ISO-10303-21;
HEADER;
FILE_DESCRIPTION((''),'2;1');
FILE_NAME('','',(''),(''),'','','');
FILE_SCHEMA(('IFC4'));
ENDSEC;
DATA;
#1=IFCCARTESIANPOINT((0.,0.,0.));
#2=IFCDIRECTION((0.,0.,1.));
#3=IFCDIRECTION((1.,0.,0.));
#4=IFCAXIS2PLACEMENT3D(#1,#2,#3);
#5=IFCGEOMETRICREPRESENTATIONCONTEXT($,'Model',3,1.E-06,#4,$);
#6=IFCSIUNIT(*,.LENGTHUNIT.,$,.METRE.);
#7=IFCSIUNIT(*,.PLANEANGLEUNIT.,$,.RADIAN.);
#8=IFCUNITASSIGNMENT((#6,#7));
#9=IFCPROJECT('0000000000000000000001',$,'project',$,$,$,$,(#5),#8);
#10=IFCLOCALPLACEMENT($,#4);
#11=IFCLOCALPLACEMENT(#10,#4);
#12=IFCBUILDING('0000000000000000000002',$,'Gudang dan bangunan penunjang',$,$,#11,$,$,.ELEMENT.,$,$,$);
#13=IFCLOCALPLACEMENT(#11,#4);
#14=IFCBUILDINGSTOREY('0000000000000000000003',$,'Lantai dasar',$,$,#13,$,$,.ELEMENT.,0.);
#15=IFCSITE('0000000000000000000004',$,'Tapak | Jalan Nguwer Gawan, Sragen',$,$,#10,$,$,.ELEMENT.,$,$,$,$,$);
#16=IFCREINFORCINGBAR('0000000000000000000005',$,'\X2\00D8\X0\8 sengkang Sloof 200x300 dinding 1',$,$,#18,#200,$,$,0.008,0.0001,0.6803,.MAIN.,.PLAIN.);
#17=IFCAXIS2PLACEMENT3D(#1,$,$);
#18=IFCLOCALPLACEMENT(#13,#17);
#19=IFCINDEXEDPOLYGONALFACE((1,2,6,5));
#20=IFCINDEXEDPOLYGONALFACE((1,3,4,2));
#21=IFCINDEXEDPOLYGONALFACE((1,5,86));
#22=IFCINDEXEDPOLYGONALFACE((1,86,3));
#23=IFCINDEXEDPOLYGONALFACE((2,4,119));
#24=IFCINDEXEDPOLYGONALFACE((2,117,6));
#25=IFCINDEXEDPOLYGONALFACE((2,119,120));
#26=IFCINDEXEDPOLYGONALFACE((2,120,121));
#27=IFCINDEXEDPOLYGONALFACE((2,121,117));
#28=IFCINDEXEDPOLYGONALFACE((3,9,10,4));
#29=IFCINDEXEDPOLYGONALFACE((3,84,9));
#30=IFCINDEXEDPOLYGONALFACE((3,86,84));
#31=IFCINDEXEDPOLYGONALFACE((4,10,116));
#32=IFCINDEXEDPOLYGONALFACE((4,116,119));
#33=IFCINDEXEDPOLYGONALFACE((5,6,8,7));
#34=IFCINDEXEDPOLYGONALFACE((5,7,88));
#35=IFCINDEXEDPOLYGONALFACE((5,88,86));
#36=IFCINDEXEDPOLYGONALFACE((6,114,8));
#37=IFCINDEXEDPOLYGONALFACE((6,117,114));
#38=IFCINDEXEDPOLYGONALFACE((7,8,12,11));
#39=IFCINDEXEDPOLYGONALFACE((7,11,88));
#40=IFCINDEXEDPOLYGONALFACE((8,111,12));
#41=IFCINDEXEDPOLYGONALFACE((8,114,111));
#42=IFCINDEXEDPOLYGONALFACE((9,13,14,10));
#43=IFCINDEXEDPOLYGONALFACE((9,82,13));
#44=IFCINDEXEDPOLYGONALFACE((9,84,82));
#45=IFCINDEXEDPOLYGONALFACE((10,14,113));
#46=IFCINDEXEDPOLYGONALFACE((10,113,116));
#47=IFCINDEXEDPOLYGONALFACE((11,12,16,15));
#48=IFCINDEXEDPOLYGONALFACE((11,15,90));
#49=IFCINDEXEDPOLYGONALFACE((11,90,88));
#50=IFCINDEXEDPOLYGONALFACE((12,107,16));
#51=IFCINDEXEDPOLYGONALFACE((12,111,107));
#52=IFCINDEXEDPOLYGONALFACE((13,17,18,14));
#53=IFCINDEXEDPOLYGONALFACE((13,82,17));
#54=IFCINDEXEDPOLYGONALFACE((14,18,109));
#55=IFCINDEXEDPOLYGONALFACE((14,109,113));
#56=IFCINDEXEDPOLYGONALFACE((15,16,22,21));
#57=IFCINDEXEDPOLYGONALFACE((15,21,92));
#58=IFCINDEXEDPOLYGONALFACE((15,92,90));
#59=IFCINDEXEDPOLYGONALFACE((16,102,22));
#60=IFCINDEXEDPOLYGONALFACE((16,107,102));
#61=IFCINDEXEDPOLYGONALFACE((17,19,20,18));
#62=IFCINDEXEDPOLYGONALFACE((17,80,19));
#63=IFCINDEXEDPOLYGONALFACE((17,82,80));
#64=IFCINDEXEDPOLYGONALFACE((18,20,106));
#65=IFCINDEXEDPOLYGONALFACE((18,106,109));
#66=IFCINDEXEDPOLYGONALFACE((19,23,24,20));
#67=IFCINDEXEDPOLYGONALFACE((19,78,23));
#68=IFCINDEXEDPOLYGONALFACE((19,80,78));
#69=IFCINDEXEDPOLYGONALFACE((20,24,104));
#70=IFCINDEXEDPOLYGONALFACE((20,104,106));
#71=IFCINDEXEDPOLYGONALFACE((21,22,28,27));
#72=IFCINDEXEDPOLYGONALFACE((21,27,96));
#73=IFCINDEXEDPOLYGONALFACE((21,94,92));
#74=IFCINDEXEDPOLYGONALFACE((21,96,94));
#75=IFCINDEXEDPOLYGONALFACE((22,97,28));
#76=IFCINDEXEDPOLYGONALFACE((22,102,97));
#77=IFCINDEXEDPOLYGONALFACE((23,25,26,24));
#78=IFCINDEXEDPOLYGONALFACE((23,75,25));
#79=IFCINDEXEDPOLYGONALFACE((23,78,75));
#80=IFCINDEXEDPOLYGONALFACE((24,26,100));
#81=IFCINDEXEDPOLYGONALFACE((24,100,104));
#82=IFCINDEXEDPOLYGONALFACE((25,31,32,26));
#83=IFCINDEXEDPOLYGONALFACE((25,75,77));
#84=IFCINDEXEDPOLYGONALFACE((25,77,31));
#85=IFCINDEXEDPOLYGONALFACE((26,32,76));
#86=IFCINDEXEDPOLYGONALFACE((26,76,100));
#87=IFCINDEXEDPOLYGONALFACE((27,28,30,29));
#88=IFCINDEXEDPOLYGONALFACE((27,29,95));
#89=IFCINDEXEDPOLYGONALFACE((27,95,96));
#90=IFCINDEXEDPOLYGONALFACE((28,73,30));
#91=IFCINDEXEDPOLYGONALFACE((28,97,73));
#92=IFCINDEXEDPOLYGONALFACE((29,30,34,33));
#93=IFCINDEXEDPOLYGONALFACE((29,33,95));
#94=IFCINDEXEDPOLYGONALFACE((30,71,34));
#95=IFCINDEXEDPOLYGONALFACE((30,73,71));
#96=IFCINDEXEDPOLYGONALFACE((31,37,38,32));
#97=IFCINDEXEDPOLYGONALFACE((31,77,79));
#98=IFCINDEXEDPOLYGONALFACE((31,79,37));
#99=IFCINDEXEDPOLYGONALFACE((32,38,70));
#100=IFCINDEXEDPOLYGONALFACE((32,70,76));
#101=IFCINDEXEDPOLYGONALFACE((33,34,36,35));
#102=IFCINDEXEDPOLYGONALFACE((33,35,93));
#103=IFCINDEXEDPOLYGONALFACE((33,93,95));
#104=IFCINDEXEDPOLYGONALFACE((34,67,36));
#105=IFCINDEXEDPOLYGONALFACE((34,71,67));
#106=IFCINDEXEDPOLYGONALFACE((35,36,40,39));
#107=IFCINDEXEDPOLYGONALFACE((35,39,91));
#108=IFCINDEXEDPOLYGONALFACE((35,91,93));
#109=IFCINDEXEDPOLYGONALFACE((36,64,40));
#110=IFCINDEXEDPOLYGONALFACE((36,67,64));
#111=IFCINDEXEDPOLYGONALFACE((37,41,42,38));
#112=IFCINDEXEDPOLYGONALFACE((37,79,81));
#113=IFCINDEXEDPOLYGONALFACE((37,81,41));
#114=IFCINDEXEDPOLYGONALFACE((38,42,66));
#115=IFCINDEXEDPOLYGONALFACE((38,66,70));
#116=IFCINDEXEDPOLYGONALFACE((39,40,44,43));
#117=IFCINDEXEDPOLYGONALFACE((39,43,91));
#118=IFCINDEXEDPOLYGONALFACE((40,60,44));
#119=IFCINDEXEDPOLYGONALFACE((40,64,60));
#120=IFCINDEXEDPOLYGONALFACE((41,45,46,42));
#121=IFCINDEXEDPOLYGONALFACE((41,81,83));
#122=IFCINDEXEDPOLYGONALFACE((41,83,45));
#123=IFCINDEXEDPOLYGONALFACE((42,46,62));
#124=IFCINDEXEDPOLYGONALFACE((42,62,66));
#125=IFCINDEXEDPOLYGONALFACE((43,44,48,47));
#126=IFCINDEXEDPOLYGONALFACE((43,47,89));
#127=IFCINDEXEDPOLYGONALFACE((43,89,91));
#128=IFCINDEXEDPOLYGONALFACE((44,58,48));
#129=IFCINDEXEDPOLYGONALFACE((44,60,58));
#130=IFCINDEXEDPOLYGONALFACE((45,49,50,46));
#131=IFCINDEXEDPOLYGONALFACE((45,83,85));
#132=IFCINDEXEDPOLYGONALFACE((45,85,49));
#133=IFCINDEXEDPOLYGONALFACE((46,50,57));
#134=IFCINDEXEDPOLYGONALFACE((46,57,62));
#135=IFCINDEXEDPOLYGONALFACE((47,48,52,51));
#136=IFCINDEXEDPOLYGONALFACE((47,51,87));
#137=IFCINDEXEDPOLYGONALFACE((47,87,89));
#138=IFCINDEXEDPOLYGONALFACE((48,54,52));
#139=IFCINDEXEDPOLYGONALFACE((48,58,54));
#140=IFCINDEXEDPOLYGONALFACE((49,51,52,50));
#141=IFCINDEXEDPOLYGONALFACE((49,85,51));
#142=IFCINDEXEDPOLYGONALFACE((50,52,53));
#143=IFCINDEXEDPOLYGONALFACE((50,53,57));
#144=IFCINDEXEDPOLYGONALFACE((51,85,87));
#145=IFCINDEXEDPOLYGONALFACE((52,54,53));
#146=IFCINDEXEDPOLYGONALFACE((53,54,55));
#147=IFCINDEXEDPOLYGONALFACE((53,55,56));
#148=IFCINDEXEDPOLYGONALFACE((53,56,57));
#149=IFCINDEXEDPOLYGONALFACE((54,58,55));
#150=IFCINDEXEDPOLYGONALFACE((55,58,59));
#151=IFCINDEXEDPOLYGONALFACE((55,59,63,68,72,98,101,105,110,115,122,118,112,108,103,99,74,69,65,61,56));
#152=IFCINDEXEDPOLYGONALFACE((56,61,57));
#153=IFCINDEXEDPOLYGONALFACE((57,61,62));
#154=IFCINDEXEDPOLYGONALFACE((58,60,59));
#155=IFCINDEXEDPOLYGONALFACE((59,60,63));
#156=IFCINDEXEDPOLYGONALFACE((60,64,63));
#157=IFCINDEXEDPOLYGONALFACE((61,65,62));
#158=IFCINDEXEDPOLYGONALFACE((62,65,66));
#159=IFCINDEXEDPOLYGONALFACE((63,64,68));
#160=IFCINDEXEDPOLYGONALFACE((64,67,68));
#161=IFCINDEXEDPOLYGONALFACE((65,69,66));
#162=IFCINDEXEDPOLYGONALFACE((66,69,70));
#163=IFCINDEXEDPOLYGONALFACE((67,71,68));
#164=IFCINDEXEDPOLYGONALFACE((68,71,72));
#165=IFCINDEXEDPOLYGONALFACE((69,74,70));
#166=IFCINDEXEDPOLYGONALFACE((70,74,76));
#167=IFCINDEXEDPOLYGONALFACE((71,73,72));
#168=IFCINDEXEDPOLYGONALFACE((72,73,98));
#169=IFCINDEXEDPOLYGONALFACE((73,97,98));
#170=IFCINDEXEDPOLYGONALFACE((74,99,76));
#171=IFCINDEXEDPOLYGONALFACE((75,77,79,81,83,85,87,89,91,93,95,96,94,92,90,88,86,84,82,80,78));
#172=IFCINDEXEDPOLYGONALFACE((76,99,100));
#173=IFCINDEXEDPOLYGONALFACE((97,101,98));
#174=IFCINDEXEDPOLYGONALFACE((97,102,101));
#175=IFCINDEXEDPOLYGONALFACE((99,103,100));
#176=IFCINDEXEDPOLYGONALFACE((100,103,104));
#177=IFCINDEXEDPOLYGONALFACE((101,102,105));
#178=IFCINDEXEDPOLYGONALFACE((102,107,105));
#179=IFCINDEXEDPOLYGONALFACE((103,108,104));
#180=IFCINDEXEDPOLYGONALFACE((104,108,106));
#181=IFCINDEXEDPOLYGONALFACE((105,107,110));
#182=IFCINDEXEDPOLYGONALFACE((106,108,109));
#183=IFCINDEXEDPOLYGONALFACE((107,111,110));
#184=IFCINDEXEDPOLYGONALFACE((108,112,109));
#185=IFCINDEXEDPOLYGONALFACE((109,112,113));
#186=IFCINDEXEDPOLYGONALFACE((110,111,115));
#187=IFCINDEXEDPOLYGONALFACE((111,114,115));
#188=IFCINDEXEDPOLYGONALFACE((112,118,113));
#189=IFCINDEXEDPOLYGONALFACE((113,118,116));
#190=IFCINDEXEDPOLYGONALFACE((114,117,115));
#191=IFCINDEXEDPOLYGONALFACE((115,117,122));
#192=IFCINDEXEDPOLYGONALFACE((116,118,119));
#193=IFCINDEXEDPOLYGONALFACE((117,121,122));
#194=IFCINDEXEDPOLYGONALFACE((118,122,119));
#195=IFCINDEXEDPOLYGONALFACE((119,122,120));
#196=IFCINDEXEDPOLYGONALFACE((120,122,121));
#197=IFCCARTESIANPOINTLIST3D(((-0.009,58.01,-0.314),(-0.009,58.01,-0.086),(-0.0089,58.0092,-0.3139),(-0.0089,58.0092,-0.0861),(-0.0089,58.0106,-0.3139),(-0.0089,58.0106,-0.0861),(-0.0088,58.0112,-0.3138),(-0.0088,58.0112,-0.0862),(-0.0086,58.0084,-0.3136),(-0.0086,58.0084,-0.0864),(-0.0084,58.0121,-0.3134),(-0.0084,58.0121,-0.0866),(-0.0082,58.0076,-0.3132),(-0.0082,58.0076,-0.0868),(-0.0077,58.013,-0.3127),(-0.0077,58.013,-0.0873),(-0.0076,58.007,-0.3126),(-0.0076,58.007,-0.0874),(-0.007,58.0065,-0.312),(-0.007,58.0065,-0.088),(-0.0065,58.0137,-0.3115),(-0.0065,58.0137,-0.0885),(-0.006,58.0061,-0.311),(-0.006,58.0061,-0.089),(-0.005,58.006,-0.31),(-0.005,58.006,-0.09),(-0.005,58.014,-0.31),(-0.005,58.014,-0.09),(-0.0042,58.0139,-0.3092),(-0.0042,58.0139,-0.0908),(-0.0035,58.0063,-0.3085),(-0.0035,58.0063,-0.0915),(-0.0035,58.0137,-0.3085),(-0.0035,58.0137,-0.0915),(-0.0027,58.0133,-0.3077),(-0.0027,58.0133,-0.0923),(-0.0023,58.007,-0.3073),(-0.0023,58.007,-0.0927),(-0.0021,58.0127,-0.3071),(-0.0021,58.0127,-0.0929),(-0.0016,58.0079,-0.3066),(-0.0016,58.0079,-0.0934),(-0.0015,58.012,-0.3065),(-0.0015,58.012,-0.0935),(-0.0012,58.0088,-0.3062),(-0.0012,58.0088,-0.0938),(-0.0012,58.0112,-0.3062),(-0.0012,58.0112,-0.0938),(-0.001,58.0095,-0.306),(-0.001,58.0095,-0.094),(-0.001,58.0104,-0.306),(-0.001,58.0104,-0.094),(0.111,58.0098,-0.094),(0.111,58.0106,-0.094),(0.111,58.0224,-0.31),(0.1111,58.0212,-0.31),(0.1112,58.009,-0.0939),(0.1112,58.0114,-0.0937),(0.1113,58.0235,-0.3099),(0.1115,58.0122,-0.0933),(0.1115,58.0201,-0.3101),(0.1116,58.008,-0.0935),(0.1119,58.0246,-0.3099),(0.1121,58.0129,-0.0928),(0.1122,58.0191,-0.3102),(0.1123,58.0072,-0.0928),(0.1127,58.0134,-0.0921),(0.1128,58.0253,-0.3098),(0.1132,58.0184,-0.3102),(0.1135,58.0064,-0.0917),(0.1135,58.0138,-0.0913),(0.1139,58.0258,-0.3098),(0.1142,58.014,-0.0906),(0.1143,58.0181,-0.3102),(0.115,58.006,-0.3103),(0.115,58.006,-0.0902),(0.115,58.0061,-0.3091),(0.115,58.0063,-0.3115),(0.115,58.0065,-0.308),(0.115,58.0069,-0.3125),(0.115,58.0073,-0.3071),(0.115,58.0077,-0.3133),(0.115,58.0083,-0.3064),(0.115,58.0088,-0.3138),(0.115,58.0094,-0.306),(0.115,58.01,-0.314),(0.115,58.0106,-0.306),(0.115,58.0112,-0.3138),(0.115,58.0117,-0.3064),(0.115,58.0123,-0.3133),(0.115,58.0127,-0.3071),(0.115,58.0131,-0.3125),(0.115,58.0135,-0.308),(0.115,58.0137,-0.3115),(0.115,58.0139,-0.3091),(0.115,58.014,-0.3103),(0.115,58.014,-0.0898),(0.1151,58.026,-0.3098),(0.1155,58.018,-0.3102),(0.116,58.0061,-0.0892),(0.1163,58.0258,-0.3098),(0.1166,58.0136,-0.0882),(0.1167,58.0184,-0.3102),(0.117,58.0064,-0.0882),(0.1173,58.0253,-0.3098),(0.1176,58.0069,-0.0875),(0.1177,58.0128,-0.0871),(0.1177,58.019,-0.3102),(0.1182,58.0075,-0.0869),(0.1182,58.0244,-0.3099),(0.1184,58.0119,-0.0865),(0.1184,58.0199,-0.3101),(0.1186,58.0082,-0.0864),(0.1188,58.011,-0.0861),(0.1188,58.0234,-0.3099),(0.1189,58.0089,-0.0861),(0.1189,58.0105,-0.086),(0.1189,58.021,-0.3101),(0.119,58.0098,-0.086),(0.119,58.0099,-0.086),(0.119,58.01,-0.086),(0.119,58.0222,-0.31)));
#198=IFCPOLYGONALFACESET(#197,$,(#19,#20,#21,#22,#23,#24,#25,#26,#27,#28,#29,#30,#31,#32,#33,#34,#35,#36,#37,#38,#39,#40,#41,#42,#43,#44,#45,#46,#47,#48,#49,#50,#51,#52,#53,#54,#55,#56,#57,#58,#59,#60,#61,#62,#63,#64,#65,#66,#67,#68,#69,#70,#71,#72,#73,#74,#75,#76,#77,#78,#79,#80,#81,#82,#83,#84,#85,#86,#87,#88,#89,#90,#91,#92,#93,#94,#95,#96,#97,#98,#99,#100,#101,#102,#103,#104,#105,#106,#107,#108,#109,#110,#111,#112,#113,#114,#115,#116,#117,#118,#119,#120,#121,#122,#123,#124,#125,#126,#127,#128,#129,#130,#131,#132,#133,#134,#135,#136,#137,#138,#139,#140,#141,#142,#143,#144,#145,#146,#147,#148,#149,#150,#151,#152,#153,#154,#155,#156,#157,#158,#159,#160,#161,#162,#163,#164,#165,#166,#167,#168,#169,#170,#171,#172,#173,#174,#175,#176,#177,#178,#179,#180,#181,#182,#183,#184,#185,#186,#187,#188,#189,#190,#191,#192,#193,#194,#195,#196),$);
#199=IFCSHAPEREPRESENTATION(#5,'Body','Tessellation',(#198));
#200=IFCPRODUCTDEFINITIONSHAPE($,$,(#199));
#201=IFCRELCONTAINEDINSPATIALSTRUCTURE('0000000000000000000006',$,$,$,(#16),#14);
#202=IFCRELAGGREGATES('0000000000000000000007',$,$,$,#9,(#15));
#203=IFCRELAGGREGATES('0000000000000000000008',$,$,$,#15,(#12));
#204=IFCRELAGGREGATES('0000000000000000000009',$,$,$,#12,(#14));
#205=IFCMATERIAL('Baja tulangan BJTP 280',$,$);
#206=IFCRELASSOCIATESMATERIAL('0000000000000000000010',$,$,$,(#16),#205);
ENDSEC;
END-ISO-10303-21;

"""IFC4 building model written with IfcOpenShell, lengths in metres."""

from ifc_helpers import new_model, entity, si_unit, origin_with_axes, place, context, project, spatial, material, element, save


model = new_model("IFC4")

# Units and contexts
model_context = context("Model", 3, precision=1e-06, world=origin_with_axes())
ifc_project = project(units=[si_unit("LENGTHUNIT", "METRE"), si_unit("PLANEANGLEUNIT", "RADIAN")], contexts=[model_context])

# Site, building, storey
site_placement = place(None, origin_with_axes())
site = spatial("IfcSite", under=ifc_project, at=site_placement, Name="Tapak | Jalan Nguwer Gawan, Sragen", CompositionType="ELEMENT")
building_placement = place(site_placement, origin_with_axes())
building = spatial("IfcBuilding", under=site, at=building_placement, Name="Gudang dan bangunan penunjang", CompositionType="ELEMENT")
storey_placement = place(building_placement, origin_with_axes())
storey = spatial("IfcBuildingStorey", under=building, at=storey_placement, Name="Lantai dasar", CompositionType="ELEMENT", Elevation=0.0)

# Shared definitions
placement = place(None, origin_with_axes())

# Reinforcing bar
ifc_material_1 = material(Name="Baja tulangan BJTP 280")
element("IfcReinforcingBar", 1, at=placement, inside=storey, material=ifc_material_1, Name="Ø8 sengkang Sloof 200x300 dinding 1", BarLength=0.6803, BarSurface="PLAIN", CrossSectionArea=0.0001, NominalDiameter=0.008, PredefinedType="MAIN", context=model_context, shape_type="AdvancedSweptSolid", body=[
    entity("IfcSweptDiskSolid", entity("IfcPolyline", [entity("IfcCartesianPoint", [0.115, 58.01, -0.31]), entity("IfcCartesianPoint", [-0.005, 58.01, -0.31]), entity("IfcCartesianPoint", [-0.005, 58.01, -0.09]), entity("IfcCartesianPoint", [0.115, 58.01, -0.09]), entity("IfcCartesianPoint", [0.115, 58.022, -0.31])]), 0.004),
])

save(model, "model.ifc")
